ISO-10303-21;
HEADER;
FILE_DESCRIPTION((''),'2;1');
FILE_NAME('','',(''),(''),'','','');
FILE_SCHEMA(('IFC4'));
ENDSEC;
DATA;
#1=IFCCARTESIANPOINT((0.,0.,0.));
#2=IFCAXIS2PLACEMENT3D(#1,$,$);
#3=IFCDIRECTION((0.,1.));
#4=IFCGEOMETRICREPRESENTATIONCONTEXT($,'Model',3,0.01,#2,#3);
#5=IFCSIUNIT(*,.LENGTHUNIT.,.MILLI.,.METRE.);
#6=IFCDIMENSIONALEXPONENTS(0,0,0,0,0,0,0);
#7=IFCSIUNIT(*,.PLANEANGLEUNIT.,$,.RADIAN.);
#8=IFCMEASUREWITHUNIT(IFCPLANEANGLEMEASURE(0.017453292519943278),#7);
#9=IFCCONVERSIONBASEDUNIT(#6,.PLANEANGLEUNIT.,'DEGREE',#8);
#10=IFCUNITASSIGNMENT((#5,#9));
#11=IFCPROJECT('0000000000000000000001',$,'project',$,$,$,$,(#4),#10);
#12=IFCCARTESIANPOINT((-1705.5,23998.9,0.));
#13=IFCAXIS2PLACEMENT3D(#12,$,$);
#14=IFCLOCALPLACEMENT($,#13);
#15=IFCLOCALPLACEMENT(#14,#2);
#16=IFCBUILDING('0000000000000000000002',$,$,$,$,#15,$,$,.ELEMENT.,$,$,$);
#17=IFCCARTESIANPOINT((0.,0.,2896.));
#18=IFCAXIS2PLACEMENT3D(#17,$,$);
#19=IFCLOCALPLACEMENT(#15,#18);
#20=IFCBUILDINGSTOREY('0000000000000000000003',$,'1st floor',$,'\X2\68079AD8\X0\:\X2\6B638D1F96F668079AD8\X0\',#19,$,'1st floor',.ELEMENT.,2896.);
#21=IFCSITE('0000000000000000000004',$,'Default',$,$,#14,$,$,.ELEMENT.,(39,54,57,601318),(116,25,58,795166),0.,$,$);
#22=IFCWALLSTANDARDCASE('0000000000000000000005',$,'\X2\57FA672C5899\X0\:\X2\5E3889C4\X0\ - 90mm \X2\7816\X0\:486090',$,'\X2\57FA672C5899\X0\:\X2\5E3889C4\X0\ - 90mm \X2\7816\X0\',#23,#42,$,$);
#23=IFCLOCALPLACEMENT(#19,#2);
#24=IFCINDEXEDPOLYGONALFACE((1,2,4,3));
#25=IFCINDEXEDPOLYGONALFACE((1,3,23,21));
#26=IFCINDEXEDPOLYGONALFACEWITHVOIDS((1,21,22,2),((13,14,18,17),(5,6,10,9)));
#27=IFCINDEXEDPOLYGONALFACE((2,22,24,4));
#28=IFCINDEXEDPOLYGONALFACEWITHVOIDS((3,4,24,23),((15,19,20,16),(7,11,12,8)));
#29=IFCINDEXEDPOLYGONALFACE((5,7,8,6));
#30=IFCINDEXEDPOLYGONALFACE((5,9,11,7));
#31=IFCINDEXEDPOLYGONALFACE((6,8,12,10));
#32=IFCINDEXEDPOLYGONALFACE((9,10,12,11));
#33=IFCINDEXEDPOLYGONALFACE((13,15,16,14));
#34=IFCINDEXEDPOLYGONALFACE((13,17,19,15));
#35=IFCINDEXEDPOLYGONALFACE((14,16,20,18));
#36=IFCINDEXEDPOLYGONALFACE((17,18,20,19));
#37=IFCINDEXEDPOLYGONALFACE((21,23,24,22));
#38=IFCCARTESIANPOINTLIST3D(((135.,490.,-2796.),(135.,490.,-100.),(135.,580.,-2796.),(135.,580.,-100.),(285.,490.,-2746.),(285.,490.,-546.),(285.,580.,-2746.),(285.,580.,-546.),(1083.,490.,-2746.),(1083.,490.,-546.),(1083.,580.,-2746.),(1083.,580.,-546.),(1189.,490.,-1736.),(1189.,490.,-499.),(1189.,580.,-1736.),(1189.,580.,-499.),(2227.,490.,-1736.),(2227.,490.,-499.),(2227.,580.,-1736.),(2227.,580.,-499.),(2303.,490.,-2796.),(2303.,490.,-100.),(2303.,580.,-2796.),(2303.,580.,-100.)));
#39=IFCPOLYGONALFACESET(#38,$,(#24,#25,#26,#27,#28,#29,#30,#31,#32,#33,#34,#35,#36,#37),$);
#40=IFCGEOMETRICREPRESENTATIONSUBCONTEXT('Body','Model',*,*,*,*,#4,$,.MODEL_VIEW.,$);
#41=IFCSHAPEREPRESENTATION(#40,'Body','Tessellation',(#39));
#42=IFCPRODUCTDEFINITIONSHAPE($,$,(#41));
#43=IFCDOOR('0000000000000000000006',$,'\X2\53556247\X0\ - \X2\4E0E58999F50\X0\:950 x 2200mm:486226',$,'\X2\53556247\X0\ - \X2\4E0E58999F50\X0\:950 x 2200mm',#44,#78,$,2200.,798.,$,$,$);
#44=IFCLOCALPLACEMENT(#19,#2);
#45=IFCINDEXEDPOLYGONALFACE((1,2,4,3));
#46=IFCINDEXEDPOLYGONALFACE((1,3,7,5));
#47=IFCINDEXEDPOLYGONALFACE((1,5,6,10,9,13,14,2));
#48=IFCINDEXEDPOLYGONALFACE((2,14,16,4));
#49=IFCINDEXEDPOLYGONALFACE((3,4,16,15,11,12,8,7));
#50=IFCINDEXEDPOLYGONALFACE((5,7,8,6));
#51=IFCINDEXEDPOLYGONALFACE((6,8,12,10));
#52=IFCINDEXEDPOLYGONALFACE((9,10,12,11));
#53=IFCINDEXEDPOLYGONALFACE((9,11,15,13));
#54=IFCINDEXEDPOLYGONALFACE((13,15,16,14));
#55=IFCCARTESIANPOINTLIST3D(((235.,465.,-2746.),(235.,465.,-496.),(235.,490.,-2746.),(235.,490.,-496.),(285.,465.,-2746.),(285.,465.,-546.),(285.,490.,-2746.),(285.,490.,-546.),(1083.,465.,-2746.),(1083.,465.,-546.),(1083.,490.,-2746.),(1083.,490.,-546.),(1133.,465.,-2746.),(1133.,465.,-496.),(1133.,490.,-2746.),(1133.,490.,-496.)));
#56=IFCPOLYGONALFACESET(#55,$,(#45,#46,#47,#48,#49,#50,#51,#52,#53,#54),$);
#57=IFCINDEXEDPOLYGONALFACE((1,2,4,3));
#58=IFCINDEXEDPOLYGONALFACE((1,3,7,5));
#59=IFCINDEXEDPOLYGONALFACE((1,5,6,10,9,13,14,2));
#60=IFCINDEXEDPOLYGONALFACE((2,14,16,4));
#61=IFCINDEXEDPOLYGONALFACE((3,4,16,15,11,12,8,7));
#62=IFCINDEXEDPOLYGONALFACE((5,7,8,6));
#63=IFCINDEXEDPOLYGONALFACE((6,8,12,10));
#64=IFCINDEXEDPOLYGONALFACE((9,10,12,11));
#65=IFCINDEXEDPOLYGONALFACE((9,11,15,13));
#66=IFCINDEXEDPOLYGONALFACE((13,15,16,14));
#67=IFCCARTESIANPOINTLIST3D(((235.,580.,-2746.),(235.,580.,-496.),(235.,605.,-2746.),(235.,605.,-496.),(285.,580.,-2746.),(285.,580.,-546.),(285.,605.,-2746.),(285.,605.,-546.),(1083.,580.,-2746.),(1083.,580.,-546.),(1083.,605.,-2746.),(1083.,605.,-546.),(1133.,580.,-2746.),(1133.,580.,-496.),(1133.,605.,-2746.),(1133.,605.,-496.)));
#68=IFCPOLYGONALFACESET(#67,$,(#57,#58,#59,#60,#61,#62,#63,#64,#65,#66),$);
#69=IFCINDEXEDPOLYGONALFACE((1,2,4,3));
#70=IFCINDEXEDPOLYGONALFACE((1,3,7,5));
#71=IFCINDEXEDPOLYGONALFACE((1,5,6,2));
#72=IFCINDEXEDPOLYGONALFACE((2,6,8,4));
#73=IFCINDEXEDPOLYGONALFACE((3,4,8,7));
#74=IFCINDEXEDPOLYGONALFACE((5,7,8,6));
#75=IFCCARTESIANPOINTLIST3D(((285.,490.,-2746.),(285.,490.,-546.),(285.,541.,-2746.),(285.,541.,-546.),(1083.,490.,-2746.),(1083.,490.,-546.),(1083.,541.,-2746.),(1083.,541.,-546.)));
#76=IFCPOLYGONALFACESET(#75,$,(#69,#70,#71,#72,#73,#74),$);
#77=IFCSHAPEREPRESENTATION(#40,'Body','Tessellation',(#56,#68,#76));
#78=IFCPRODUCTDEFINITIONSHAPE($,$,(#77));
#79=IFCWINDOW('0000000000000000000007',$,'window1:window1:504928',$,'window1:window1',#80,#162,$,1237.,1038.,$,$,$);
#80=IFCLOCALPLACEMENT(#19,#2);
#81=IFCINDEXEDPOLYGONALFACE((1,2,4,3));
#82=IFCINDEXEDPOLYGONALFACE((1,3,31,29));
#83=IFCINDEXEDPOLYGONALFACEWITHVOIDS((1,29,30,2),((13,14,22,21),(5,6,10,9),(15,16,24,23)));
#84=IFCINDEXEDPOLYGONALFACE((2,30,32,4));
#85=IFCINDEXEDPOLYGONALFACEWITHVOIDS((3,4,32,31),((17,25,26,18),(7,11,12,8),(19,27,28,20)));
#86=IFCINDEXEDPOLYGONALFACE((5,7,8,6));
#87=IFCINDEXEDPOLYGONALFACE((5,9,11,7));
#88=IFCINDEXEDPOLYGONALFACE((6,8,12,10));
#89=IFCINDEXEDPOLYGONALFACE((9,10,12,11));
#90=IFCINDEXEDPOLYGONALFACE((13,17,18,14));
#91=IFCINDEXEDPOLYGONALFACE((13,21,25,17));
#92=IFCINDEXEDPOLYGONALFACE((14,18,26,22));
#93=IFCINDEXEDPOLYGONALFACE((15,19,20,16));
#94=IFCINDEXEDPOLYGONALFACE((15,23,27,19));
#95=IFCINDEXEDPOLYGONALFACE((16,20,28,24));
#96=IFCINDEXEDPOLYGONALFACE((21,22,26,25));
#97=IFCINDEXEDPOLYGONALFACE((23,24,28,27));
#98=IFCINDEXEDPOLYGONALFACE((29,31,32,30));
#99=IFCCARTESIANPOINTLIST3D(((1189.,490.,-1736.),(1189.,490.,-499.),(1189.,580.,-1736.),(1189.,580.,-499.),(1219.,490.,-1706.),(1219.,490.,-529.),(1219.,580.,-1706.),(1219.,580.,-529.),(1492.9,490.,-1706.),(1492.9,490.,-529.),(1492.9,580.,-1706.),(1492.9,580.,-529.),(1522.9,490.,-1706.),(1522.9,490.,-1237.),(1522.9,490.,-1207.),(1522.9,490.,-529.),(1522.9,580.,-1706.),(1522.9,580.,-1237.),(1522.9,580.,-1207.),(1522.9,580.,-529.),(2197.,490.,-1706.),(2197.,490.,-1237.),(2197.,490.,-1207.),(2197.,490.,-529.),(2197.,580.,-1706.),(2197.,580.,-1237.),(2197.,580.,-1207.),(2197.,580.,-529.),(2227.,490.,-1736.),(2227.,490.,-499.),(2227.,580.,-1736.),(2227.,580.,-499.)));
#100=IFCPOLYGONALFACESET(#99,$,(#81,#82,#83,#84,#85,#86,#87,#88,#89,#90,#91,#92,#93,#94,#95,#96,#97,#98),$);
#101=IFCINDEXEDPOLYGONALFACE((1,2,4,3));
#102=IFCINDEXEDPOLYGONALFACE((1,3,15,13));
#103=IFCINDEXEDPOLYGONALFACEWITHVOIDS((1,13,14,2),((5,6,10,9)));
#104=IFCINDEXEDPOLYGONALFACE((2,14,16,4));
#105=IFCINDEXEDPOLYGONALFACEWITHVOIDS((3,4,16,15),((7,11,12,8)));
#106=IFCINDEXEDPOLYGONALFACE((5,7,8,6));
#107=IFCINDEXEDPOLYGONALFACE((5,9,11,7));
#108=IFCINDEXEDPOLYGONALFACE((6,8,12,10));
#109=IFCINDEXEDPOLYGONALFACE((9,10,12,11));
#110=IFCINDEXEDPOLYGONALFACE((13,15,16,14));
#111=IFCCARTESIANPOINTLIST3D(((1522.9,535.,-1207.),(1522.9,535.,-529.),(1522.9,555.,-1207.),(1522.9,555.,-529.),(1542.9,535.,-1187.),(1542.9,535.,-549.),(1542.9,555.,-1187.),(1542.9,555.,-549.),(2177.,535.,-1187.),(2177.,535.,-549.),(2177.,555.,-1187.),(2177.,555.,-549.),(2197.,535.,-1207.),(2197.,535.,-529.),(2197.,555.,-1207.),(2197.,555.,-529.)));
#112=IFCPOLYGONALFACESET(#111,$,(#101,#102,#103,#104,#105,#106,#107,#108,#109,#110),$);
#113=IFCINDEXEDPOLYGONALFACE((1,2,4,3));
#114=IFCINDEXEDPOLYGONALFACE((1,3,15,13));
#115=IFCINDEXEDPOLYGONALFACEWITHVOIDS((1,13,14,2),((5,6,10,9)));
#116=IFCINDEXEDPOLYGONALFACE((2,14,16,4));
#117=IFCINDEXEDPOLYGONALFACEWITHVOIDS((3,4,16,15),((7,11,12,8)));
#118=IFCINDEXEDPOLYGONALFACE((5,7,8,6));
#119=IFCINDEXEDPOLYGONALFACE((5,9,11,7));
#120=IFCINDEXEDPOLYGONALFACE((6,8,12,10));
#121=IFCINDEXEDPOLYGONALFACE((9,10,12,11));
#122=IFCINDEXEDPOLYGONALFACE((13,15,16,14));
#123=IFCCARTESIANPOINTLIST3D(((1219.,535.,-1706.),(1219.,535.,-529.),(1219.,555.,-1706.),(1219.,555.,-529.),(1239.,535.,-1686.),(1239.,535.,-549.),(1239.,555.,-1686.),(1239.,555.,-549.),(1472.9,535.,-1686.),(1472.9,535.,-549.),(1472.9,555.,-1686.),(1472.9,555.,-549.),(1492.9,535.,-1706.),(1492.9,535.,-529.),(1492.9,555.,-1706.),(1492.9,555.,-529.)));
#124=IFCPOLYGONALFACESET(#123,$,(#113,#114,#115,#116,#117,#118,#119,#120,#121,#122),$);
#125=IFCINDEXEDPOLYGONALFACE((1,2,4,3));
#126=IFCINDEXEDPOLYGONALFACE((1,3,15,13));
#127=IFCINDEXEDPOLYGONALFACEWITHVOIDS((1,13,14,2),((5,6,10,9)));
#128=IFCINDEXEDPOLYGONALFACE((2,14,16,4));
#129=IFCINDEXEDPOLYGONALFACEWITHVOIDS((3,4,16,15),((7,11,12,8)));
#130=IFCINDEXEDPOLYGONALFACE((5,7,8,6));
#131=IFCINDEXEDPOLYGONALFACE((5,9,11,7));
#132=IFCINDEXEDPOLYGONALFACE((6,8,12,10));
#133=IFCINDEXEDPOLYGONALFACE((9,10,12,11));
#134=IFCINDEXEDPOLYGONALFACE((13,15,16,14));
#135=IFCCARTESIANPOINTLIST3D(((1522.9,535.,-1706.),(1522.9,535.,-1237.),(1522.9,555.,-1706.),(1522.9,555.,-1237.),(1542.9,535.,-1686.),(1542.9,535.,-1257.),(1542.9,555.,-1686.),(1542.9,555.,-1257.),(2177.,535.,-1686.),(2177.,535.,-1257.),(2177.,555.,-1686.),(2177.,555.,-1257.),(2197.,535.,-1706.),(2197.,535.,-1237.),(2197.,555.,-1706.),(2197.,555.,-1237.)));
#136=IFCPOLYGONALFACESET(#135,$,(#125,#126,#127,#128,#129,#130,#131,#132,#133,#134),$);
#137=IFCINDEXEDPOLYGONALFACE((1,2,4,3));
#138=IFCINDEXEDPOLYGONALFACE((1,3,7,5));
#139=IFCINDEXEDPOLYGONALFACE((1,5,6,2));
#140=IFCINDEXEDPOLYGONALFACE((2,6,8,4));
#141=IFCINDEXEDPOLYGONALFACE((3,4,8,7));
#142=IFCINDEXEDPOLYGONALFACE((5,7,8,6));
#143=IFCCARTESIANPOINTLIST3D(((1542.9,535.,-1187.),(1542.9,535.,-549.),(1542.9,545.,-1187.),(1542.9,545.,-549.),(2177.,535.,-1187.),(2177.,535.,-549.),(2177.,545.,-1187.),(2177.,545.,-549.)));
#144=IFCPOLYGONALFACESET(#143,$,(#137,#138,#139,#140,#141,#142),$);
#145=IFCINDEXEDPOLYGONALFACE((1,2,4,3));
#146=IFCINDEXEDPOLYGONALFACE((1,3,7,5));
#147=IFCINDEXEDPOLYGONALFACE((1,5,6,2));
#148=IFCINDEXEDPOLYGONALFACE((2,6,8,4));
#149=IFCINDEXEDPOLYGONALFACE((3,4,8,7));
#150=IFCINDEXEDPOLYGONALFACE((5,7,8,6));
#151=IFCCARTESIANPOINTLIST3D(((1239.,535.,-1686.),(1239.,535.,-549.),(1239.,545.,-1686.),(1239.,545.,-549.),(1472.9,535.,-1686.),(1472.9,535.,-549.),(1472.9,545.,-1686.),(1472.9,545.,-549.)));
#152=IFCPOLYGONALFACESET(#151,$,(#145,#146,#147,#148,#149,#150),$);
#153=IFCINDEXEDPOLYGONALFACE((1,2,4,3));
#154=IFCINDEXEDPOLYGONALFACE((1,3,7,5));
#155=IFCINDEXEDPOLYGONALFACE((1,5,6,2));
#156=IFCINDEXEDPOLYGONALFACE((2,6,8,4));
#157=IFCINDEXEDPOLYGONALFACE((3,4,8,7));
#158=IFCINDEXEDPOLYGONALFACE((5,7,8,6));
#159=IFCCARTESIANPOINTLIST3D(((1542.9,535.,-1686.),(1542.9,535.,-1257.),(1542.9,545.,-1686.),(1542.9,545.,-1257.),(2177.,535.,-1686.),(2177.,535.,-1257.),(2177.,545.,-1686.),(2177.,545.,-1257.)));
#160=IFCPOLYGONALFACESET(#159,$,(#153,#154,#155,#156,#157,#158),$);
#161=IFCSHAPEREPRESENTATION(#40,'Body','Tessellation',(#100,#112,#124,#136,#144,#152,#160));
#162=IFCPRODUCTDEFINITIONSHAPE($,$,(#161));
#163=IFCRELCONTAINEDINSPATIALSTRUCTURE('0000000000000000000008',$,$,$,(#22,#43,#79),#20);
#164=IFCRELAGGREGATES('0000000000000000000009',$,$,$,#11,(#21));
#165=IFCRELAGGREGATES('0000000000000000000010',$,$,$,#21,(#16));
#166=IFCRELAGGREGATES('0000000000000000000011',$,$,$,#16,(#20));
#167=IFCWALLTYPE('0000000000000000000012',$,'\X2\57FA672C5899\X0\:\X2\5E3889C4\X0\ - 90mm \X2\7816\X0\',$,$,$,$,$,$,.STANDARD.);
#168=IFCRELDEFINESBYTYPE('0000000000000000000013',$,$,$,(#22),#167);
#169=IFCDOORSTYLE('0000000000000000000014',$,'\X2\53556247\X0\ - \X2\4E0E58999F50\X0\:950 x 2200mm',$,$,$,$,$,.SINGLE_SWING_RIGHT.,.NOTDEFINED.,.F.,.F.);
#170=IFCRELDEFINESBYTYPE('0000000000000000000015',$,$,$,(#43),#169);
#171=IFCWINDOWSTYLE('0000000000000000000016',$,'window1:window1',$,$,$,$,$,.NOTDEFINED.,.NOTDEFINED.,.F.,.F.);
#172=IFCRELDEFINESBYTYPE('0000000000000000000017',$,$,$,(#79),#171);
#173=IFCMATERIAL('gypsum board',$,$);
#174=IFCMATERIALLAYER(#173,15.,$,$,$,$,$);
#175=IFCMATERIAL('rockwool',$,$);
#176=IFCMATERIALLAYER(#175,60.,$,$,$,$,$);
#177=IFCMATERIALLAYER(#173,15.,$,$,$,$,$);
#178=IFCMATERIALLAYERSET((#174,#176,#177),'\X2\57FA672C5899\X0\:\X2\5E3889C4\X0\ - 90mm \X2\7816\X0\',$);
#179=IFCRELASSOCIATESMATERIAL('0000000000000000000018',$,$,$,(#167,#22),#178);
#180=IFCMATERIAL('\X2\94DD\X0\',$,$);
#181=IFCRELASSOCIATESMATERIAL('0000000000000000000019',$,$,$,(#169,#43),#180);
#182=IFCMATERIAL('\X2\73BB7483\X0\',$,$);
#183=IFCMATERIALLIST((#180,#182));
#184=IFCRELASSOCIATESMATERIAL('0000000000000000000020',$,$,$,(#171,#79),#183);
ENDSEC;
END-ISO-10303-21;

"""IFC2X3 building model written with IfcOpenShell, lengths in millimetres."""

from ifc_helpers import new_model, entity, si_unit, converted_unit, direction, frame, frame_2d, origin, origin_2d_with_axis, place, context, subcontext, project, spatial, polyline, rectangle, outline, extrude, source, transform, mapped, material, material_list, layer, layer_set, layer_usage, type_object, type_shapes, element, fill, save


model = new_model("IFC2X3")

# Units and contexts
model_context = context("Model", 3, precision=0.01, world=origin(), true_north=direction((0.0, 1.0)))
body_context = subcontext(model_context, "Body", "Model", "MODEL_VIEW")
ifc_project = project(units=[si_unit("LENGTHUNIT", "METRE", prefix="MILLI"), converted_unit("PLANEANGLEUNIT", "DEGREE", entity("IfcPlaneAngleMeasure", 0.017453292519943278), si_unit("PLANEANGLEUNIT", "RADIAN"), dimensions=[0, 0, 0, 0, 0, 0, 0])], contexts=[model_context])

# Site, building, storey
site_placement = place(None, frame((-1705.5, 23998.9, 0.0)))
site = spatial("IfcSite", under=ifc_project, at=site_placement, Name="Default", CompositionType="ELEMENT", RefLatitude=(39, 54, 57, 601318), RefLongitude=(116, 25, 58, 795166), RefElevation=0.0)
building_placement = place(site_placement, origin())
building = spatial("IfcBuilding", under=site, at=building_placement, CompositionType="ELEMENT")
storey_placement = place(building_placement, frame((0.0, 0.0, 2896.0)))
storey = spatial("IfcBuildingStorey", under=building, at=storey_placement, Name="1st floor", ObjectType="标高:正负零标高", LongName="1st floor", CompositionType="ELEMENT", Elevation=2896.0)

# Wall, openings, door, window
ifc_material_1 = material(Name="gypsum board")
ifc_layer_1 = layer(ifc_material_1, 15.0)
ifc_material_2 = material(Name="rockwool")
ifc_layer_2 = layer(ifc_material_2, 60.0)
ifc_layer_3 = layer(ifc_material_1, 15.0)
ifc_layer_set_1 = layer_set([ifc_layer_1, ifc_layer_2, ifc_layer_3], Name="基本墙:常规 - 90mm 砖")
ifc_layer_usage_1 = layer_usage(ifc_layer_set_1, "AXIS2", "NEGATIVE", 45.0)
wall_type = type_object("IfcWallType", Name="基本墙:常规 - 90mm 砖", PredefinedType="STANDARD", material=ifc_layer_set_1)
wall_placement = place(storey_placement, frame((2303.0, 535.0, -2796.0), z_axis=(0.0, 0.0, 1.0), x_axis=(-1.0, 0.0, 0.0)))
wall = element("IfcWallStandardCase", 1, at=wall_placement, inside=storey, type_object=wall_type, material=ifc_layer_usage_1, Name="基本墙:常规 - 90mm 砖:486090", ObjectType="基本墙:常规 - 90mm 砖", context=body_context, shape_type="SweptSolid", body=[
    extrude(rectangle(XDim=2168.0, YDim=90.0, at=frame_2d((1084.0, 0.0), x_axis=(-1.0, 0.0))), origin(), (0.0, 0.0, 1.0), 2696.0),
])
opening_1_placement = place(wall_placement, frame((1220.0, -45.0, 50.0)))
opening_1 = element("IfcOpeningElement", 2, at=opening_1_placement, cuts=wall, ObjectType="Opening", context=body_context, shape_type="SweptSolid", body=[
    extrude(rectangle(XDim=798.0, YDim=2200.0, at=frame_2d((1100.0, 399.0), x_axis=(0.0, 1.0))), frame((0.0, 0.0, 0.0), z_axis=(0.0, 1.0, 0.0), x_axis=(0.0, 0.0, 1.0)), (0.0, 0.0, 1.0), 90.0),
])
opening_2_placement = place(wall_placement, frame((76.0, -45.0, 1060.0)))
opening_2 = element("IfcOpeningElement", 3, at=opening_2_placement, cuts=wall, ObjectType="Opening", context=body_context, shape_type="SweptSolid", body=[
    extrude(rectangle(XDim=1237.0, YDim=1038.0, at=frame_2d((618.5, 519.0), x_axis=(1.0, 0.0))), frame((0.0, 0.0, 0.0), z_axis=(0.0, 1.0, 0.0), x_axis=(0.0, 0.0, 1.0)), (0.0, 0.0, 1.0), 90.0),
])
ifc_material_3 = material(Name="铝")
door_style = type_object("IfcDoorStyle", Name="单扇 - 与墙齐:950 x 2200mm", ConstructionType="NOTDEFINED", OperationType="SINGLE_SWING_RIGHT", ParameterTakesPrecedence=False, Sizeable=False, material=ifc_material_3)
shared_shape_1 = source(origin(), body_context, "Body", "SweptSolid", [
    extrude(outline(polyline([(-449.0, -1137.5), (449.0, -1137.5), (449.0, 1112.5), (399.0, 1112.5), (399.0, -1087.5), (-399.0, -1087.5), (-399.0, 1112.5), (-449.0, 1112.5), (-449.0, -1137.5)])), frame((399.0, 90.0, 1112.5), z_axis=(0.0, 1.0, 0.0), x_axis=(1.0, 0.0, 0.0)), (0.0, 0.0, 1.0), 25.0),
    extrude(outline(polyline([(-1137.5, -449.0), (1112.5, -449.0), (1112.5, -399.0), (-1087.5, -399.0), (-1087.5, 399.0), (1112.5, 399.0), (1112.5, 449.0), (-1137.5, 449.0), (-1137.5, -449.0)])), frame((399.0, -25.0, 1112.5), z_axis=(0.0, 1.0, 0.0), x_axis=(0.0, 0.0, -1.0)), (0.0, 0.0, 1.0), 25.0),
    extrude(rectangle(XDim=51.0, YDim=798.0, at=origin_2d_with_axis()), frame((399.0, 64.5, 0.0), z_axis=(0.0, 0.0, 1.0), x_axis=(0.0, 1.0, 0.0)), (0.0, 0.0, 1.0), 2200.0),
])
type_shapes(door_style, [shared_shape_1])
door_placement = place(opening_1_placement, origin())
door = element("IfcDoor", 4, at=door_placement, inside=storey, type_object=door_style, material=ifc_material_3, Name="单扇 - 与墙齐:950 x 2200mm:486226", ObjectType="单扇 - 与墙齐:950 x 2200mm", OverallHeight=2200.0, OverallWidth=798.0, context=body_context, shape_type="MappedRepresentation", body=[
    mapped(shared_shape_1, transform((0.0, 0.0, 0.0), scale=1.0)),
])
fill(opening_1, door)
ifc_material_4 = material(Name="玻璃")
ifc_material_list = material_list([ifc_material_3, ifc_material_4])
window_style = type_object("IfcWindowStyle", Name="window1:window1", ConstructionType="NOTDEFINED", OperationType="NOTDEFINED", ParameterTakesPrecedence=False, Sizeable=False, material=ifc_material_list)
shared_shape_2 = source(origin(), body_context, "Body", "SweptSolid", [
    extrude(outline(polyline([(-618.5, -519.0), (618.5, -519.0), (618.5, 519.0), (-618.5, 519.0), (-618.5, -519.0)]), holes=[polyline([(-588.5, -215.1), (588.5, -215.1), (588.5, -489.0), (-588.5, -489.0), (-588.5, -215.1)]), polyline([(89.5, -185.1), (-588.5, -185.1), (-588.5, 489.0), (89.5, 489.0), (89.5, -185.1)]), polyline([(119.5, 489.0), (588.5, 489.0), (588.5, -185.1), (119.5, -185.1), (119.5, 489.0)])]), frame((519.0, 0.0, 618.5), z_axis=(0.0, 1.0, 0.0), x_axis=(0.0, 0.0, -1.0)), (0.0, 0.0, 1.0), 90.0),
    extrude(outline(polyline([(-337.0, -339.0), (337.0, -339.0), (337.0, 339.0), (-337.0, 339.0), (-337.0, -339.0)]), holes=[polyline([(-317.0, -319.0), (-317.0, 319.0), (317.0, 319.0), (317.0, -319.0), (-317.0, -319.0)])]), frame((367.0, 25.0, 868.0), z_axis=(0.0, 1.0, 0.0), x_axis=(1.0, 0.0, 0.0)), (0.0, 0.0, 1.0), 20.0),
    extrude(outline(polyline([(-137.0, -588.5), (137.0, -588.5), (137.0, 588.5), (-137.0, 588.5), (-137.0, -588.5)]), holes=[polyline([(-117.0, -568.5), (-117.0, 568.5), (117.0, 568.5), (117.0, -568.5), (-117.0, -568.5)])]), frame((871.0, 25.0, 618.5), z_axis=(0.0, 1.0, 0.0), x_axis=(1.0, 0.0, 0.0)), (0.0, 0.0, 1.0), 20.0),
    extrude(outline(polyline([(-337.0, -234.5), (337.0, -234.5), (337.0, 234.5), (-337.0, 234.5), (-337.0, -234.5)]), holes=[polyline([(-317.0, -214.5), (-317.0, 214.5), (317.0, 214.5), (317.0, -214.5), (-317.0, -214.5)])]), frame((367.0, 25.0, 264.5), z_axis=(0.0, 1.0, 0.0), x_axis=(1.0, 0.0, 0.0)), (0.0, 0.0, 1.0), 20.0),
    extrude(rectangle(XDim=10.0, YDim=634.1, at=frame_2d((0.0, 0.0), x_axis=(1.0, 0.0))), frame((367.0, 40.0, 549.0), z_axis=(0.0, 0.0, 1.0), x_axis=(0.0, 1.0, 0.0)), (0.0, 0.0, 1.0), 638.0),
    extrude(rectangle(XDim=10.0, YDim=233.9, at=frame_2d((0.0, 0.0), x_axis=(1.0, 0.0))), frame((871.0, 40.0, 50.0), z_axis=(0.0, 0.0, 1.0), x_axis=(0.0, 1.0, 0.0)), (0.0, 0.0, 1.0), 1137.0),
    extrude(rectangle(XDim=10.0, YDim=634.1, at=origin_2d_with_axis()), frame((367.0, 40.0, 50.0), z_axis=(0.0, 0.0, 1.0), x_axis=(0.0, 1.0, 0.0)), (0.0, 0.0, 1.0), 429.0),
])
type_shapes(window_style, [shared_shape_2])
window_placement = place(opening_2_placement, origin())
window = element("IfcWindow", 5, at=window_placement, inside=storey, type_object=window_style, material=ifc_material_list, Name="window1:window1:504928", ObjectType="window1:window1", OverallHeight=1237.0, OverallWidth=1038.0, context=body_context, shape_type="MappedRepresentation", body=[
    mapped(shared_shape_2, transform((0.0, 0.0, 0.0), scale=1.0)),
])
fill(opening_2, window)

save(model, "model.ifc")
